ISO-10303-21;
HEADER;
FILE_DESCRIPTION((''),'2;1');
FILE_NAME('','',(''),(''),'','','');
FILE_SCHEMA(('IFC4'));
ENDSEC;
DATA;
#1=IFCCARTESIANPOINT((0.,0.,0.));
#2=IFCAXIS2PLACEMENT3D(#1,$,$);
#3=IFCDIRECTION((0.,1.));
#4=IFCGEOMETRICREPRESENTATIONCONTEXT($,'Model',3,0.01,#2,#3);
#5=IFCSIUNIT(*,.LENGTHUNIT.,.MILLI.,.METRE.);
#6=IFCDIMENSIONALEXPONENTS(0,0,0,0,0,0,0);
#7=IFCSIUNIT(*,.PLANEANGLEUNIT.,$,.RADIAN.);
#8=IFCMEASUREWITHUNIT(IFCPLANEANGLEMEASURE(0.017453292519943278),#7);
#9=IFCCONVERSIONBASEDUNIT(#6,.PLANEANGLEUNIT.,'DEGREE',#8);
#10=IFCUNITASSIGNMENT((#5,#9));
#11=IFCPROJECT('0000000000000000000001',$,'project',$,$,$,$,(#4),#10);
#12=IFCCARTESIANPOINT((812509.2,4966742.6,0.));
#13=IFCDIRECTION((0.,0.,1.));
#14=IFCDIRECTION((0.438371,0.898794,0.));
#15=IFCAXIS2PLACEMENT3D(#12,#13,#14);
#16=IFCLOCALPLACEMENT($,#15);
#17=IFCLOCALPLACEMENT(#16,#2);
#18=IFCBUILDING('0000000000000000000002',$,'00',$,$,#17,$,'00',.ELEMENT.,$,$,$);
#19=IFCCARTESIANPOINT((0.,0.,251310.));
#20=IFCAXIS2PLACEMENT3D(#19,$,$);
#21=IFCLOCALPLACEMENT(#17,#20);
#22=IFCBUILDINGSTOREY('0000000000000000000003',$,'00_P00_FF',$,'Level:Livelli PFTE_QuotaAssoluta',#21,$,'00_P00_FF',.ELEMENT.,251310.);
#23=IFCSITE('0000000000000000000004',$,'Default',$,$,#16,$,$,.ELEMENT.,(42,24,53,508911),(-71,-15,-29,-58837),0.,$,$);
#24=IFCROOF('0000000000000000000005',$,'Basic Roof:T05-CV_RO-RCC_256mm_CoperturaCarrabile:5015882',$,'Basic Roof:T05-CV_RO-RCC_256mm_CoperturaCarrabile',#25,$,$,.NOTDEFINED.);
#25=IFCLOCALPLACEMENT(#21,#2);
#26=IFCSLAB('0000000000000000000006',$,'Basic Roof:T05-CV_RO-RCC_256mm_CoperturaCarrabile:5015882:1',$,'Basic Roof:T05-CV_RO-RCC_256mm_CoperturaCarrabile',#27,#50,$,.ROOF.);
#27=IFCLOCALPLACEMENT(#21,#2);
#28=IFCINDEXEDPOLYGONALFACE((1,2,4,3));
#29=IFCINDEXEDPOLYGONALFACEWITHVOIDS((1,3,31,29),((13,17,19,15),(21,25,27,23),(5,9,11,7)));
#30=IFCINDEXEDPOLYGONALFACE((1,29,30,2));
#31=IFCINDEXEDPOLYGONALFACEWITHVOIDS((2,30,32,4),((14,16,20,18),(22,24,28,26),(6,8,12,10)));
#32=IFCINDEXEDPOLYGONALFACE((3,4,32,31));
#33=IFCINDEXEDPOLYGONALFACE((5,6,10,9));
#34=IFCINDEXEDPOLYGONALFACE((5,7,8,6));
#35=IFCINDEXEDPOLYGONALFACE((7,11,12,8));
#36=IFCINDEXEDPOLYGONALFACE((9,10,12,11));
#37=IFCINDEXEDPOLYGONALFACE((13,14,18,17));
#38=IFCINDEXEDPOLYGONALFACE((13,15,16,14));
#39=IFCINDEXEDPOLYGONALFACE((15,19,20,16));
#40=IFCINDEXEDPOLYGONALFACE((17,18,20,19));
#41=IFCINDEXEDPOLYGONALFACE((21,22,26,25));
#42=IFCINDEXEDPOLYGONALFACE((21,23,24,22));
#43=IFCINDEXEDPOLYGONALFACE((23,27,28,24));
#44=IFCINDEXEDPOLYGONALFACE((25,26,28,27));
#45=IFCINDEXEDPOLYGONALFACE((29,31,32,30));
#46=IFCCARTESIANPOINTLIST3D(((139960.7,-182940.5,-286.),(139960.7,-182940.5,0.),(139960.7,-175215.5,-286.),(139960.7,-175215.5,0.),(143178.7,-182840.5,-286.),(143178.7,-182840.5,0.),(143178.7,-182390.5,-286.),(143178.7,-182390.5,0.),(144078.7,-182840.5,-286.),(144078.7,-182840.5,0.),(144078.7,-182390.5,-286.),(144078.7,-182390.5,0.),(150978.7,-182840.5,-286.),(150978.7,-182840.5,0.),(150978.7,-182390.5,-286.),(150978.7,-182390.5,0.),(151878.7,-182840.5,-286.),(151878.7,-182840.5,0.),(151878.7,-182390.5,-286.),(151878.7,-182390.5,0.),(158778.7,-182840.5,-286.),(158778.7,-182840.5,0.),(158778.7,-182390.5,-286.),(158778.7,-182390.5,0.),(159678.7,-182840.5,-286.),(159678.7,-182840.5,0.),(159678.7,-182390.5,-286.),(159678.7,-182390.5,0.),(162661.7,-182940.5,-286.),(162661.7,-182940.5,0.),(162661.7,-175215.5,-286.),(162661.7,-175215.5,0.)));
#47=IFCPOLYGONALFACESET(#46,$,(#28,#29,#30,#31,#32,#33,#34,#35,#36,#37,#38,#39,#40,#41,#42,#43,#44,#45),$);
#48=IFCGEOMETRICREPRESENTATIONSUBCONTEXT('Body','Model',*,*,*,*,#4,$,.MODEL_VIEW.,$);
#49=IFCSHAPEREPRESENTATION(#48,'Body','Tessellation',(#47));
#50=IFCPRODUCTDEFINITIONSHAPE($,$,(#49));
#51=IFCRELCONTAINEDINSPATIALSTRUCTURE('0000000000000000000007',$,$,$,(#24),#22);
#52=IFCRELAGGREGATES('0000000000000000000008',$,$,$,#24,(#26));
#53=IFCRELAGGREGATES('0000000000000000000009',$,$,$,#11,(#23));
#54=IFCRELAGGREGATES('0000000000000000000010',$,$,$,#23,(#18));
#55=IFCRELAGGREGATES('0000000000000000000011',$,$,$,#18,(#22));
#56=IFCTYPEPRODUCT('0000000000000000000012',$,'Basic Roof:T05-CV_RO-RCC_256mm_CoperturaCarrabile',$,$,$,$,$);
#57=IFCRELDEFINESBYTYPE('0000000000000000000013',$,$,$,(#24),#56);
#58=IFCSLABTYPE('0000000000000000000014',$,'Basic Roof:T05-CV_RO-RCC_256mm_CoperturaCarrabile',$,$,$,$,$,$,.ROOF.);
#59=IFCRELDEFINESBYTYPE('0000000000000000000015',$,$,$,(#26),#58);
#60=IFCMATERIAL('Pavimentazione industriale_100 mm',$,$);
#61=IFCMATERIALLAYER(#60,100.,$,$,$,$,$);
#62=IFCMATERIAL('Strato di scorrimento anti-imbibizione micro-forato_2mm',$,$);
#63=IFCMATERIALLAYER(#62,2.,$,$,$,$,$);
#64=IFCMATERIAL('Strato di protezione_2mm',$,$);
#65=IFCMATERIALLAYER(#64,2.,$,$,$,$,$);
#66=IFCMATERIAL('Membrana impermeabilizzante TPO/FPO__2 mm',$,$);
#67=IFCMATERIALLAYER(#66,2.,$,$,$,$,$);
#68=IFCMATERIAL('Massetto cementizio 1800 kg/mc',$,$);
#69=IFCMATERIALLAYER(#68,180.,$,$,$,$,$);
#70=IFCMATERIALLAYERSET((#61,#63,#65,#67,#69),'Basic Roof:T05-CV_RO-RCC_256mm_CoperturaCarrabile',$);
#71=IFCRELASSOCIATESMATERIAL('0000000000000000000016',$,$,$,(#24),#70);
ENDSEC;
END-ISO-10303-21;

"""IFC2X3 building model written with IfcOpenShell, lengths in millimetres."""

from ifc_helpers import new_model, entity, si_unit, converted_unit, direction, frame, frame_2d, origin, origin_2d_with_axis, place, context, subcontext, project, spatial, rectangle, extrude, material, layer, layer_set, type_object, element, aggregate, save


model = new_model("IFC2X3")

# Units and contexts
model_context = context("Model", 3, precision=0.01, world=origin(), true_north=direction((0.0, 1.0)))
body_context = subcontext(model_context, "Body", "Model", "MODEL_VIEW")
ifc_project = project(units=[si_unit("LENGTHUNIT", "METRE", prefix="MILLI"), converted_unit("PLANEANGLEUNIT", "DEGREE", entity("IfcPlaneAngleMeasure", 0.017453292519943278), si_unit("PLANEANGLEUNIT", "RADIAN"), dimensions=[0, 0, 0, 0, 0, 0, 0])], contexts=[model_context])

# Site, building, storey
site_placement = place(None, frame((812509.2, 4966742.6, 0.0), z_axis=(0.0, 0.0, 1.0), x_axis=(0.438371, 0.898794, 0.0)))
site = spatial("IfcSite", under=ifc_project, at=site_placement, Name="Default", CompositionType="ELEMENT", RefLatitude=(42, 24, 53, 508911), RefLongitude=(-71, -15, -29, -58837), RefElevation=0.0)
building_placement = place(site_placement, origin())
building = spatial("IfcBuilding", under=site, at=building_placement, Name="00", LongName="00", CompositionType="ELEMENT")
storey_placement = place(building_placement, frame((0.0, 0.0, 251310.0)))
storey = spatial("IfcBuildingStorey", under=building, at=storey_placement, Name="00_P00_FF", ObjectType="Level:Livelli PFTE_QuotaAssoluta", LongName="00_P00_FF", CompositionType="ELEMENT", Elevation=251310.0)

# Roof, slab, openings
ifc_material_1 = material(Name="Pavimentazione industriale_100 mm")
ifc_layer_1 = layer(ifc_material_1, 100.0)
ifc_material_2 = material(Name="Strato di scorrimento anti-imbibizione micro-forato_2mm")
ifc_layer_2 = layer(ifc_material_2, 2.0)
ifc_material_3 = material(Name="Strato di protezione_2mm")
ifc_layer_3 = layer(ifc_material_3, 2.0)
ifc_material_4 = material(Name="Membrana impermeabilizzante TPO/FPO__2 mm")
ifc_layer_4 = layer(ifc_material_4, 2.0)
ifc_material_5 = material(Name="Massetto cementizio 1800 kg/mc")
ifc_layer_5 = layer(ifc_material_5, 180.0)
ifc_layer_set = layer_set([ifc_layer_1, ifc_layer_2, ifc_layer_3, ifc_layer_4, ifc_layer_5], Name="Basic Roof:T05-CV_RO-RCC_256mm_CoperturaCarrabile")
type_product = type_object("IfcTypeProduct", Name="Basic Roof:T05-CV_RO-RCC_256mm_CoperturaCarrabile")
roof_placement = place(storey_placement, origin())
roof = element("IfcRoof", 1, at=roof_placement, inside=storey, type_object=type_product, material=ifc_layer_set, Name="Basic Roof:T05-CV_RO-RCC_256mm_CoperturaCarrabile:5015882", ObjectType="Basic Roof:T05-CV_RO-RCC_256mm_CoperturaCarrabile", ShapeType="NOTDEFINED")
slab_type = type_object("IfcSlabType", Name="Basic Roof:T05-CV_RO-RCC_256mm_CoperturaCarrabile", PredefinedType="ROOF")
slab_placement = place(storey_placement, origin())
slab = element("IfcSlab", 2, at=slab_placement, type_object=slab_type, Name="Basic Roof:T05-CV_RO-RCC_256mm_CoperturaCarrabile:5015882:1", ObjectType="Basic Roof:T05-CV_RO-RCC_256mm_CoperturaCarrabile", PredefinedType="ROOF", context=body_context, shape_type="SweptSolid", body=[
    extrude(rectangle(XDim=7725.0, YDim=22701.0, at=frame_2d((0.0, 0.0), x_axis=(1.0, 0.0))), frame((151311.2, -179078.0, -286.0), z_axis=(0.0, 0.0, 1.0), x_axis=(0.0, 1.0, 0.0)), (0.0, 0.0, 1.0), 286.0),
])
opening_1_placement = place(storey_placement, origin())
element("IfcOpeningElement", 3, at=opening_1_placement, cuts=slab, ObjectType="Opening", context=body_context, shape_type="SweptSolid", body=[
    extrude(rectangle(XDim=900.0, YDim=450.0, at=origin_2d_with_axis()), frame((159228.7, -182615.5, -286.0)), (0.0, 0.0, 1.0), 286.0),
])
opening_2_placement = place(storey_placement, origin())
element("IfcOpeningElement", 4, at=opening_2_placement, cuts=slab, ObjectType="Opening", context=body_context, shape_type="SweptSolid", body=[
    extrude(rectangle(XDim=900.0, YDim=450.0, at=origin_2d_with_axis()), frame((151428.7, -182615.5, -286.0)), (0.0, 0.0, 1.0), 286.0),
])
opening_3_placement = place(storey_placement, origin())
element("IfcOpeningElement", 5, at=opening_3_placement, cuts=slab, ObjectType="Opening", context=body_context, shape_type="SweptSolid", body=[
    extrude(rectangle(XDim=900.0, YDim=450.0, at=frame_2d((0.0, 0.0), x_axis=(1.0, 0.0))), frame((143628.7, -182615.5, -286.0)), (0.0, 0.0, 1.0), 286.0),
])
aggregate(roof, [slab])

save(model, "model.ifc")
